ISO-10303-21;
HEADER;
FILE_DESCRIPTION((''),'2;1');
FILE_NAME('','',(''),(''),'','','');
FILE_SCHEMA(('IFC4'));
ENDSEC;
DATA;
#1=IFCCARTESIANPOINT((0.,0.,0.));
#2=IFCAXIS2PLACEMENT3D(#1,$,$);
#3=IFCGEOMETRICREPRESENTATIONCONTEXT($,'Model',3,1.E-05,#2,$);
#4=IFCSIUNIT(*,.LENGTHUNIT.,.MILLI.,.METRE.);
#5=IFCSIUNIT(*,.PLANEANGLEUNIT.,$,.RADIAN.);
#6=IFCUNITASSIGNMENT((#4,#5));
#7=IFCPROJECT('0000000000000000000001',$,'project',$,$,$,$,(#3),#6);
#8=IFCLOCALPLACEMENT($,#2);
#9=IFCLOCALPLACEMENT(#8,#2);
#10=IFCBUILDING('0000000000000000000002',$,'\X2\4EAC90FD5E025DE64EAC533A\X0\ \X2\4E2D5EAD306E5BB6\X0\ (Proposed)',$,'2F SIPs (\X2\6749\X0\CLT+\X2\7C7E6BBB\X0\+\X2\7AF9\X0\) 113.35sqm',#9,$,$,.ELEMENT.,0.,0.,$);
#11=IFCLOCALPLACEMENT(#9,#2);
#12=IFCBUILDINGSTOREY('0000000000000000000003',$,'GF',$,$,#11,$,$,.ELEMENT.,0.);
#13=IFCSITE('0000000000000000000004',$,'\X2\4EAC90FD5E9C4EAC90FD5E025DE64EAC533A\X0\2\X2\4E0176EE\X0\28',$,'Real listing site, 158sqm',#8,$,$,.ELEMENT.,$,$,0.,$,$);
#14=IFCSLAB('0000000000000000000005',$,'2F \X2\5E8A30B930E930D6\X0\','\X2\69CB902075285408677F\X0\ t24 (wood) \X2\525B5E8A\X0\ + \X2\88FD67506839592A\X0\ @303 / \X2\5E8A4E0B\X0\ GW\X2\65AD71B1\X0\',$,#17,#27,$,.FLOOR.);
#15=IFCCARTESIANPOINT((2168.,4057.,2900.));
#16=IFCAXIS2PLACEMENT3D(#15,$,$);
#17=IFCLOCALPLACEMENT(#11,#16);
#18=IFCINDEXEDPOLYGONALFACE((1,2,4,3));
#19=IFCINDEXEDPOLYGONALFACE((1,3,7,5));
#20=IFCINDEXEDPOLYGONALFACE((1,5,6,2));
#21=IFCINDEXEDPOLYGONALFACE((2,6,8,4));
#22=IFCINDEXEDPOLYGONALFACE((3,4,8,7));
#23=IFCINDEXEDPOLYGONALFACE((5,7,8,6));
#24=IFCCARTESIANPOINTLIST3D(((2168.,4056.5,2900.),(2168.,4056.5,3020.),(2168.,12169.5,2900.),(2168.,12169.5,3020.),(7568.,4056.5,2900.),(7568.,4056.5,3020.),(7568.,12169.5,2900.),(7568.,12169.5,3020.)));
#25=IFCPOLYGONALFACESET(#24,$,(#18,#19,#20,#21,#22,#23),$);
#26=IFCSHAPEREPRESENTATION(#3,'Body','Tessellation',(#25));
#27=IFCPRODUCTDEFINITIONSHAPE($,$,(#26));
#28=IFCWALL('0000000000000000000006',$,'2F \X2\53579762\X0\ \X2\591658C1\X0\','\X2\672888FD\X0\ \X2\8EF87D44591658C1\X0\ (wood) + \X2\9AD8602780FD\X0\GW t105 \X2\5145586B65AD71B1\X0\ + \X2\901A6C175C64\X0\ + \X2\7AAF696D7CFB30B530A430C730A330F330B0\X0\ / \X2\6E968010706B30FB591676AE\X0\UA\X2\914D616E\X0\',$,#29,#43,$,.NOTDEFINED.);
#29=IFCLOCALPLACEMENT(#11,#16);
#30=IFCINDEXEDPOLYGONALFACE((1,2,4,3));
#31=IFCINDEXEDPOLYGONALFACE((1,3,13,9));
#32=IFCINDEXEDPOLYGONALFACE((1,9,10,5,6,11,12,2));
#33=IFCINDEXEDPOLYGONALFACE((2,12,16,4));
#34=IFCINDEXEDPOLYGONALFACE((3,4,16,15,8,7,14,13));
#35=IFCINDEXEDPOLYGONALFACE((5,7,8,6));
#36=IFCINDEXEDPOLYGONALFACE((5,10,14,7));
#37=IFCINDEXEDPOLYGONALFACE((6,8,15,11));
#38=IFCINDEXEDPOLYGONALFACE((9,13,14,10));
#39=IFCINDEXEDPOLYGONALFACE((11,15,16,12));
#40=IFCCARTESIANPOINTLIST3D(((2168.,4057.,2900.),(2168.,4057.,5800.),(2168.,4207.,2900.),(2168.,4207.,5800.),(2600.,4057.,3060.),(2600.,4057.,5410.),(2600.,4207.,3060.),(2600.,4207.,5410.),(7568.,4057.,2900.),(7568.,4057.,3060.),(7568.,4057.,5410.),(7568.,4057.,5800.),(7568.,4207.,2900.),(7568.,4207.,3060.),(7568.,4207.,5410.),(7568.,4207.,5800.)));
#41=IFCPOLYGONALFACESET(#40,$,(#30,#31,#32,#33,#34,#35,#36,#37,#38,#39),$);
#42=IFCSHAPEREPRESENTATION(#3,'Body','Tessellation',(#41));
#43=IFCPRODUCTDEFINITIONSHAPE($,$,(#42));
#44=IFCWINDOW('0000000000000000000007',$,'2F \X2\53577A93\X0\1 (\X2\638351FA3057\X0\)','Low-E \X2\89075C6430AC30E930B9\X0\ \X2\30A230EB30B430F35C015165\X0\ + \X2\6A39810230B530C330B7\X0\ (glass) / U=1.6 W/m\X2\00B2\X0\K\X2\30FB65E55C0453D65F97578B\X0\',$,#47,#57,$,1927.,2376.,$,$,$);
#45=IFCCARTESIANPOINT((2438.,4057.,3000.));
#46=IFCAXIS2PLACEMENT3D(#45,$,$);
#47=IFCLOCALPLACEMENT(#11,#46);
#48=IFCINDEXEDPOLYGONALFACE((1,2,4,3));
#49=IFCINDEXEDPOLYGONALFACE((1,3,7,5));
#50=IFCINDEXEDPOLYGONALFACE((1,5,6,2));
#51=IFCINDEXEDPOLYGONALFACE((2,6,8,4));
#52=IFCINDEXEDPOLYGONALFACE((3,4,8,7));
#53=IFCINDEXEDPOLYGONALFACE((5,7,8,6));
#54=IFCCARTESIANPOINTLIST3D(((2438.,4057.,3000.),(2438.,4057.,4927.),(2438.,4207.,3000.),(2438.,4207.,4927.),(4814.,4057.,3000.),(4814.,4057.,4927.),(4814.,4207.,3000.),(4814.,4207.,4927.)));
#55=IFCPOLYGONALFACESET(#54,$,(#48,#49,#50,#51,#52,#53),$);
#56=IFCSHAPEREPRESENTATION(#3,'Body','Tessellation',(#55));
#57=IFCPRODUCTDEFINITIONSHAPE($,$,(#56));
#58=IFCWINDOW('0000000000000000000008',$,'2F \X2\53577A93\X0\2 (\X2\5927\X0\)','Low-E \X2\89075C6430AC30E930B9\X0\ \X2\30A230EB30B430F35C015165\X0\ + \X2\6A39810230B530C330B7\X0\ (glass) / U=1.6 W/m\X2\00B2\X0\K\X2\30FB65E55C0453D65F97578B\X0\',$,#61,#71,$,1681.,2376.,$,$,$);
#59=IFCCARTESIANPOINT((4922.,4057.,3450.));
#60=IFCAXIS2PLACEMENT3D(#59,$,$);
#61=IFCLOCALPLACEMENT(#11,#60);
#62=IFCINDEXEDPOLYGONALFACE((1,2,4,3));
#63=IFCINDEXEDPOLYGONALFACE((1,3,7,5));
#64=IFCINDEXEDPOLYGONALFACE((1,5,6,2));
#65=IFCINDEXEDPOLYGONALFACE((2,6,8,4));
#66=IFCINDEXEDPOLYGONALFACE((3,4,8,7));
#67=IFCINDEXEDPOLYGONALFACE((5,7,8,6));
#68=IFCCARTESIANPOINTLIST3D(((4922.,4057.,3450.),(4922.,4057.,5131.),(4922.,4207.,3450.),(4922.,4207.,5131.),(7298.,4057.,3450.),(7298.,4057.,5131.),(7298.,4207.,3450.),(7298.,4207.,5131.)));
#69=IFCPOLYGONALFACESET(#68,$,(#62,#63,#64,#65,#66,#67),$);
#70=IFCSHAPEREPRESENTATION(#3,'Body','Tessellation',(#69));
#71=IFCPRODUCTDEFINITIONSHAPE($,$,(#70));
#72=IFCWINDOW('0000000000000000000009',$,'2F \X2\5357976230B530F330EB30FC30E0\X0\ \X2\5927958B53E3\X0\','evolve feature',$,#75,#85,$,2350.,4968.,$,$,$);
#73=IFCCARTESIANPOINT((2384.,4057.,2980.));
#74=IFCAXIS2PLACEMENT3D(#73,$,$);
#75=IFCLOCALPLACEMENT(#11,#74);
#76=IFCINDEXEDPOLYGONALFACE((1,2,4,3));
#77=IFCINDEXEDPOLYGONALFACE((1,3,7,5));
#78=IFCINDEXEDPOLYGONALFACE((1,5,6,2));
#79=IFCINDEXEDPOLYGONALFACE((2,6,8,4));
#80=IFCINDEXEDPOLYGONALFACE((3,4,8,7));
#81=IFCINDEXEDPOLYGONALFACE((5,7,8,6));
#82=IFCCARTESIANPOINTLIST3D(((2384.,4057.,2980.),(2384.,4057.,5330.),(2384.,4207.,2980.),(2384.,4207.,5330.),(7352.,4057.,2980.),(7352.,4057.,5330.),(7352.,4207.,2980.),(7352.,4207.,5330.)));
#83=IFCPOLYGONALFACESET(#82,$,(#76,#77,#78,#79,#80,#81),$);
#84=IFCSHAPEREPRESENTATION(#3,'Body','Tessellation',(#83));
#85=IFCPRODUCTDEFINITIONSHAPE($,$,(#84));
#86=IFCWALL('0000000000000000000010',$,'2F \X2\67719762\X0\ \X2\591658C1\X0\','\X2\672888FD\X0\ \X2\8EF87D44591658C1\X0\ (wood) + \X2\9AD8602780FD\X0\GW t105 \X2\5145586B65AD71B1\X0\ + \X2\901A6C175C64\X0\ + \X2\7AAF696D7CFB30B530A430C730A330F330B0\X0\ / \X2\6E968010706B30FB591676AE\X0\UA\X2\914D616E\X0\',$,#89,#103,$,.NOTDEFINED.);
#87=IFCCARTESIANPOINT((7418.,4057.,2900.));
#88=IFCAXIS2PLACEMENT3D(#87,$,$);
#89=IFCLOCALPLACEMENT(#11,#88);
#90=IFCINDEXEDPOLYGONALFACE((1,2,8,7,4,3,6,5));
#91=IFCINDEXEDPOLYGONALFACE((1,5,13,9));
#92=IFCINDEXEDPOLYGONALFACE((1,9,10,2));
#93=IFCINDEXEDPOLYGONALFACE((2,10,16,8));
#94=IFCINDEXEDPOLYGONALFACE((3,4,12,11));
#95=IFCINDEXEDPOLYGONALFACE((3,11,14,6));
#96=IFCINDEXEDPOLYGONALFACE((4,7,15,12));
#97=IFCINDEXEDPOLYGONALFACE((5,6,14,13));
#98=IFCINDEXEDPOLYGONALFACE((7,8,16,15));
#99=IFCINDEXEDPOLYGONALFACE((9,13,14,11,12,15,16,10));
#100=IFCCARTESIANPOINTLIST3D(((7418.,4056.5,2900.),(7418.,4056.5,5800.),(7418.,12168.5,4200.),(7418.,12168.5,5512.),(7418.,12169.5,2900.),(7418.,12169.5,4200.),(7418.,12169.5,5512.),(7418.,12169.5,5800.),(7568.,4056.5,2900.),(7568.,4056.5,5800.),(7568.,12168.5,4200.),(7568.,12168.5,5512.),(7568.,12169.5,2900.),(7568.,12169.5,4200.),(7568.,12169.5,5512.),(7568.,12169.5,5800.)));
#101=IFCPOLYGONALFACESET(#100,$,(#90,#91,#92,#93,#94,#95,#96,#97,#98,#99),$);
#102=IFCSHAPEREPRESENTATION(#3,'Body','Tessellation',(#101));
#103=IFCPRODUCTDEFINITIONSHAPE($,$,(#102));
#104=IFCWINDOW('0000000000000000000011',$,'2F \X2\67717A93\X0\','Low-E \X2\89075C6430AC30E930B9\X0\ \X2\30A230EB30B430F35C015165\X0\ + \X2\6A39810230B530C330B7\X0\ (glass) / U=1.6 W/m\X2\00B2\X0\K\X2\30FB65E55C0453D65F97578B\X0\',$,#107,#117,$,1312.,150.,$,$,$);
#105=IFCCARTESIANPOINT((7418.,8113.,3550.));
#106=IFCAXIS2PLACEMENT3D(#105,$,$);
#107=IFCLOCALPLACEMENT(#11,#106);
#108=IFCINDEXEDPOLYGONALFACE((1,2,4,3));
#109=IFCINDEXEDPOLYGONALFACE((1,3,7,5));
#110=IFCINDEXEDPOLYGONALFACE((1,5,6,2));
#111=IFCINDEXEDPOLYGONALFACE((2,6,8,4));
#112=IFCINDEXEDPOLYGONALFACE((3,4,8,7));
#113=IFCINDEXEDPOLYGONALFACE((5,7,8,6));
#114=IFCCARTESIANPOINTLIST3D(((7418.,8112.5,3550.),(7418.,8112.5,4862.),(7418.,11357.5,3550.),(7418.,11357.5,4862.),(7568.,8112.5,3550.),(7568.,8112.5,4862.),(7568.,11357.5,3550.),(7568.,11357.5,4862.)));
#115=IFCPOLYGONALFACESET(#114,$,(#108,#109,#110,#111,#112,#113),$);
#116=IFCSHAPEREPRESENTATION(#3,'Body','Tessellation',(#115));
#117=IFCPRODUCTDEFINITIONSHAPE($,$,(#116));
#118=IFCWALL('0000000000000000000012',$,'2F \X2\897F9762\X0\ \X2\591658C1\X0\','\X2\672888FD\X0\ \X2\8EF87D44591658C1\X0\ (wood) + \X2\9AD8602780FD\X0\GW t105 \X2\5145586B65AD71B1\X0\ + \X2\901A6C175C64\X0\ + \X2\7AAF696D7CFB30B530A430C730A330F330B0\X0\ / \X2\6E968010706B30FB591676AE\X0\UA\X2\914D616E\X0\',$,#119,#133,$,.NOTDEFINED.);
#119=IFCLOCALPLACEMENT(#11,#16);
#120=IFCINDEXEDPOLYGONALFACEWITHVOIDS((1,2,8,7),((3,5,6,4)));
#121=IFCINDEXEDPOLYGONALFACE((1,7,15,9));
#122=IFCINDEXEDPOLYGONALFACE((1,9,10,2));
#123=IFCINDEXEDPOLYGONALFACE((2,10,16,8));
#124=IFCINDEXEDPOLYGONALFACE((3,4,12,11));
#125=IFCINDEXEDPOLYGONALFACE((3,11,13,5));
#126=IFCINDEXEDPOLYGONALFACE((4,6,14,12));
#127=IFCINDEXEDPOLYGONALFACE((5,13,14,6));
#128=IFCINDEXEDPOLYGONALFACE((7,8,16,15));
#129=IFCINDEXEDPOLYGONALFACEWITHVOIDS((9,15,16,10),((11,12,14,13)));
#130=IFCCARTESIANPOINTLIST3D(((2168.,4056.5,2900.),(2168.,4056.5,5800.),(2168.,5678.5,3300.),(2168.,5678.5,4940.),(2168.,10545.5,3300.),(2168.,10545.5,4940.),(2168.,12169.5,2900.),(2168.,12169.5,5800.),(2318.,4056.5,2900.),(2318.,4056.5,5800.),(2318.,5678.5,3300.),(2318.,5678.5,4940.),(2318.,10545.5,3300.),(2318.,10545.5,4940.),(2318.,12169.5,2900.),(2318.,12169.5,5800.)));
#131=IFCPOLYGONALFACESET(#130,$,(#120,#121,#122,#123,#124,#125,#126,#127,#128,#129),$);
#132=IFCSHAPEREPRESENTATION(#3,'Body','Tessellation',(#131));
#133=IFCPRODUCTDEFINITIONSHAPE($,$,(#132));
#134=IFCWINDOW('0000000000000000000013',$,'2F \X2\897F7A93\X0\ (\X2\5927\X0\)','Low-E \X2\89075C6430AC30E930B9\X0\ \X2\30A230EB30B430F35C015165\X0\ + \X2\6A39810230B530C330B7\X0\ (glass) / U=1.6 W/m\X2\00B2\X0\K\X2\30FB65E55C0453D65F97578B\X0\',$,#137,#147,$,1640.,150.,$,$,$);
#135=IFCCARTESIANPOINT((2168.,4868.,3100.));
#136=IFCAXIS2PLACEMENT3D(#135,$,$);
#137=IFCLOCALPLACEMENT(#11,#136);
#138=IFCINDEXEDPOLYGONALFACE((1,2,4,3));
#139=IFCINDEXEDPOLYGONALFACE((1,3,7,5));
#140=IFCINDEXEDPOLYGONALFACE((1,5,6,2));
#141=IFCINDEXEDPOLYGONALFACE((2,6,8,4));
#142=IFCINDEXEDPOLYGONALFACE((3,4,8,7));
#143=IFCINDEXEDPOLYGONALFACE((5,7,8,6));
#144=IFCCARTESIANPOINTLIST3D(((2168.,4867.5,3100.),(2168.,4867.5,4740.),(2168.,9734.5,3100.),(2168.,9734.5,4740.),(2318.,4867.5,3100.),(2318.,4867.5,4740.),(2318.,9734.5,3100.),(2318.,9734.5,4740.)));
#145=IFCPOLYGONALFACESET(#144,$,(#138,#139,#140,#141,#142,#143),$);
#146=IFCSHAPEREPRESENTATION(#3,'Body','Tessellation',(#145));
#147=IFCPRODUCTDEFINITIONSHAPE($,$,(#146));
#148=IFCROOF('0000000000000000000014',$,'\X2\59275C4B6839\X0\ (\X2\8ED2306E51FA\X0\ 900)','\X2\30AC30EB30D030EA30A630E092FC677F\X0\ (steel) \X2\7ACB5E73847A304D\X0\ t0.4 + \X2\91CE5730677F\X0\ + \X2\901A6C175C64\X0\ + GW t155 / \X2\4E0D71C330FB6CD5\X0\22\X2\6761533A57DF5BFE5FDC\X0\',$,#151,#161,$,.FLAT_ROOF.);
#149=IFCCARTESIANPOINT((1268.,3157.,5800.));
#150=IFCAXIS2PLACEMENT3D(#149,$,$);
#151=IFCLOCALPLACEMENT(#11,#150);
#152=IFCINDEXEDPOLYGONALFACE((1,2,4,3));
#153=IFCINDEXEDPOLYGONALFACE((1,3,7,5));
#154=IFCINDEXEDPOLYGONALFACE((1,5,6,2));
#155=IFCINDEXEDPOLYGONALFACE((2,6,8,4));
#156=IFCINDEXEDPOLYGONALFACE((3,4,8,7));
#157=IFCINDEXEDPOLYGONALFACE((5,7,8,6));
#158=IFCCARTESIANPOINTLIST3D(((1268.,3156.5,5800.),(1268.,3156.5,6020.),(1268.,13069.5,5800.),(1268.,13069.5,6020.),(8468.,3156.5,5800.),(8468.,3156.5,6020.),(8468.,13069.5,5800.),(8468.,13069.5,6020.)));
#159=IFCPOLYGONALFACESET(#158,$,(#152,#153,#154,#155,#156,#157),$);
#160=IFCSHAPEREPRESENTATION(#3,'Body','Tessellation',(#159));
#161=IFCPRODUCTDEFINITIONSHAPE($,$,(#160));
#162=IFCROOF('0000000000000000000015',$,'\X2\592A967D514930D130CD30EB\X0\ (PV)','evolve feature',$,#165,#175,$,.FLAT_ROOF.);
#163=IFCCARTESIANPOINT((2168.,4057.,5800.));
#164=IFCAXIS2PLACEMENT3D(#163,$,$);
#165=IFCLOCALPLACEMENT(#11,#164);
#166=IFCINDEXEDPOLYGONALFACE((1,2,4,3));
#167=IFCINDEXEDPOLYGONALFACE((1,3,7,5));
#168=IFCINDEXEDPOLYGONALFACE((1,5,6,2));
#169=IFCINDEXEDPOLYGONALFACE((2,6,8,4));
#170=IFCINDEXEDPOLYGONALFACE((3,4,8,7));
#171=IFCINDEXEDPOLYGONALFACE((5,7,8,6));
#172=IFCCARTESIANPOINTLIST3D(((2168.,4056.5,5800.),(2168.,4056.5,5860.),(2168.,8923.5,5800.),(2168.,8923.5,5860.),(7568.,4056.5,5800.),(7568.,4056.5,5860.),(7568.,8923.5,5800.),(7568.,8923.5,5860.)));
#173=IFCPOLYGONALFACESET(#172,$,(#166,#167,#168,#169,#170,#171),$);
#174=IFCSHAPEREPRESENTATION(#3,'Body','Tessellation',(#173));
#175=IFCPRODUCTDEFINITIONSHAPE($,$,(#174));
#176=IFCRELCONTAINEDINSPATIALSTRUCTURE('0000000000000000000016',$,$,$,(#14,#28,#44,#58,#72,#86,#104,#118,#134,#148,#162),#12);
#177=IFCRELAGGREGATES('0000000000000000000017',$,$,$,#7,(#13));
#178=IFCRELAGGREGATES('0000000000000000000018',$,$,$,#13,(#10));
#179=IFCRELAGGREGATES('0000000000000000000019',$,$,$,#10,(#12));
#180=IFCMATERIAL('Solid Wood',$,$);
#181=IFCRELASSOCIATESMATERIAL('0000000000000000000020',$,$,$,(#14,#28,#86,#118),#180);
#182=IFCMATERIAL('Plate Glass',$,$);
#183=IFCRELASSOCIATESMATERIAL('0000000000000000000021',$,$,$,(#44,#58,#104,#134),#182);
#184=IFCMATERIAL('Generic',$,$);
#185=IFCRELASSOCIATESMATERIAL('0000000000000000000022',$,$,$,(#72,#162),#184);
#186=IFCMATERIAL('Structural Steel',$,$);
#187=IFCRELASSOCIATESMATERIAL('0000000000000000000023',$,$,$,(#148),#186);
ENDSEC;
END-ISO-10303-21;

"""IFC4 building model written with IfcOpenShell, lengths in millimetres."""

from ifc_helpers import new_model, si_unit, frame, frame_2d, origin, place, context, project, spatial, rectangle, extrude, material, element, fill, save


model = new_model("IFC4")

# Units and contexts
model_context = context("Model", 3, precision=1e-05, world=origin())
ifc_project = project(units=[si_unit("LENGTHUNIT", "METRE", prefix="MILLI"), si_unit("PLANEANGLEUNIT", "RADIAN")], contexts=[model_context])

# Site, building, storey
site_placement = place(None, origin())
site = spatial("IfcSite", under=ifc_project, at=site_placement, Name="京都府京都市左京区2丁目28", ObjectType="Real listing site, 158sqm", CompositionType="ELEMENT", RefElevation=0.0)
building_placement = place(site_placement, origin())
building = spatial("IfcBuilding", under=site, at=building_placement, Name="京都市左京区 中庭の家 (Proposed)", ObjectType="2F SIPs (杉CLT+籾殻+竹) 113.35sqm", CompositionType="ELEMENT", ElevationOfRefHeight=0.0, ElevationOfTerrain=0.0)
storey_placement = place(building_placement, origin())
storey = spatial("IfcBuildingStorey", under=building, at=storey_placement, Name="GF", CompositionType="ELEMENT", Elevation=0.0)

# Slab
ifc_material_1 = material(Name="Solid Wood")
slab_placement = place(storey_placement, frame((2168.0, 4057.0, 2900.0)))
element("IfcSlab", 1, at=slab_placement, inside=storey, material=ifc_material_1, Name="2F 床スラブ", Description="構造用合板 t24 (wood) 剛床 + 製材根太 @303 / 床下 GW断熱", PredefinedType="FLOOR", context=model_context, shape_type="SweptSolid", body=[
    extrude(rectangle(XDim=5400.0, YDim=8113.0, at=frame_2d((2700.0, 4056.0))), frame((2168.0, 4057.0, 2900.0)), (0.0, 0.0, 1.0), 120.0),
])

# Wall, openings, windows
wall_1_placement = place(storey_placement, frame((2168.0, 4057.0, 2900.0)))
wall_1 = element("IfcWall", 2, at=wall_1_placement, inside=storey, material=ifc_material_1, Name="2F 南面 外壁", Description="木製 軸組外壁 (wood) + 高性能GW t105 充填断熱 + 通気層 + 窯業系サイディング / 準耐火・外皮UA配慮", PredefinedType="NOTDEFINED", context=model_context, shape_type="SweptSolid", body=[
    extrude(rectangle(XDim=5400.0, YDim=150.0, at=frame_2d((2700.0, 75.0))), frame((2168.0, 4057.0, 2900.0)), (0.0, 0.0, 1.0), 2900.0),
])
opening_1_placement = place(storey_placement, frame((2438.0, 4057.0, 3000.0)))
opening_1 = element("IfcOpeningElement", 3, at=opening_1_placement, cuts=wall_1, PredefinedType="NOTDEFINED", context=model_context, shape_type="SweptSolid", body=[
    extrude(rectangle(XDim=2376.0, YDim=150.0, at=frame_2d((1188.0, 75.0))), frame((2438.0, 4057.0, 3000.0)), (0.0, 0.0, 1.0), 1927.0),
])
opening_2_placement = place(storey_placement, frame((4922.0, 4057.0, 3450.0)))
opening_2 = element("IfcOpeningElement", 4, at=opening_2_placement, cuts=wall_1, PredefinedType="NOTDEFINED", context=model_context, shape_type="SweptSolid", body=[
    extrude(rectangle(XDim=2376.0, YDim=150.0, at=frame_2d((1188.0, 75.0))), frame((4922.0, 4057.0, 3450.0)), (0.0, 0.0, 1.0), 1681.0),
])
opening_3_placement = place(storey_placement, frame((2384.0, 4057.0, 2980.0)))
opening_3 = element("IfcOpeningElement", 5, at=opening_3_placement, cuts=wall_1, PredefinedType="NOTDEFINED", context=model_context, shape_type="SweptSolid", body=[
    extrude(rectangle(XDim=4968.0, YDim=150.0, at=frame_2d((2484.0, 75.0))), frame((2384.0, 4057.0, 2980.0)), (0.0, 0.0, 1.0), 2350.0),
])
ifc_material_2 = material(Name="Plate Glass")
window_1_placement = place(storey_placement, frame((2438.0, 4057.0, 3000.0)))
window_1 = element("IfcWindow", 6, at=window_1_placement, inside=storey, material=ifc_material_2, Name="2F 南窓1 (掃出し)", Description="Low-E 複層ガラス アルゴン封入 + 樹脂サッシ (glass) / U=1.6 W/m²K・日射取得型", OverallHeight=1927.0, OverallWidth=2376.0, context=model_context, shape_type="SweptSolid", body=[
    extrude(rectangle(XDim=2376.0, YDim=150.0, at=frame_2d((1188.0, 75.0))), frame((2438.0, 4057.0, 3000.0)), (0.0, 0.0, 1.0), 1927.0),
])
fill(opening_1, window_1)
window_2_placement = place(storey_placement, frame((4922.0, 4057.0, 3450.0)))
window_2 = element("IfcWindow", 7, at=window_2_placement, inside=storey, material=ifc_material_2, Name="2F 南窓2 (大)", Description="Low-E 複層ガラス アルゴン封入 + 樹脂サッシ (glass) / U=1.6 W/m²K・日射取得型", OverallHeight=1681.0, OverallWidth=2376.0, context=model_context, shape_type="SweptSolid", body=[
    extrude(rectangle(XDim=2376.0, YDim=150.0, at=frame_2d((1188.0, 75.0))), frame((4922.0, 4057.0, 3450.0)), (0.0, 0.0, 1.0), 1681.0),
])
fill(opening_2, window_2)
ifc_material_3 = material(Name="Generic")
window_3_placement = place(storey_placement, frame((2384.0, 4057.0, 2980.0)))
window_3 = element("IfcWindow", 8, at=window_3_placement, inside=storey, material=ifc_material_3, Name="2F 南面サンルーム 大開口", Description="evolve feature", OverallHeight=2350.0, OverallWidth=4968.0, context=model_context, shape_type="SweptSolid", body=[
    extrude(rectangle(XDim=4968.0, YDim=150.0, at=frame_2d((2484.0, 75.0))), frame((2384.0, 4057.0, 2980.0)), (0.0, 0.0, 1.0), 2350.0),
])
fill(opening_3, window_3)

# Walls, openings, windows
wall_2_placement = place(storey_placement, frame((7418.0, 4057.0, 2900.0)))
wall_2 = element("IfcWall", 9, at=wall_2_placement, inside=storey, material=ifc_material_1, Name="2F 東面 外壁", Description="木製 軸組外壁 (wood) + 高性能GW t105 充填断熱 + 通気層 + 窯業系サイディング / 準耐火・外皮UA配慮", PredefinedType="NOTDEFINED", context=model_context, shape_type="SweptSolid", body=[
    extrude(rectangle(XDim=150.0, YDim=8113.0, at=frame_2d((75.0, 4056.0))), frame((7418.0, 4057.0, 2900.0)), (0.0, 0.0, 1.0), 2900.0),
])
opening_4_placement = place(storey_placement, frame((7418.0, 8113.0, 3550.0)))
opening_4 = element("IfcOpeningElement", 10, at=opening_4_placement, cuts=wall_2, PredefinedType="NOTDEFINED", context=model_context, shape_type="SweptSolid", body=[
    extrude(rectangle(XDim=150.0, YDim=3245.0, at=frame_2d((75.0, 1622.0))), frame((7418.0, 8113.0, 3550.0)), (0.0, 0.0, 1.0), 1312.0),
])
window_4_placement = place(storey_placement, frame((7418.0, 8113.0, 3550.0)))
window_4 = element("IfcWindow", 11, at=window_4_placement, inside=storey, material=ifc_material_2, Name="2F 東窓", Description="Low-E 複層ガラス アルゴン封入 + 樹脂サッシ (glass) / U=1.6 W/m²K・日射取得型", OverallHeight=1312.0, OverallWidth=150.0, context=model_context, shape_type="SweptSolid", body=[
    extrude(rectangle(XDim=150.0, YDim=3245.0, at=frame_2d((75.0, 1622.0))), frame((7418.0, 8113.0, 3550.0)), (0.0, 0.0, 1.0), 1312.0),
])
fill(opening_4, window_4)
wall_3_placement = place(storey_placement, frame((2168.0, 4057.0, 2900.0)))
wall_3 = element("IfcWall", 12, at=wall_3_placement, inside=storey, material=ifc_material_1, Name="2F 西面 外壁", Description="木製 軸組外壁 (wood) + 高性能GW t105 充填断熱 + 通気層 + 窯業系サイディング / 準耐火・外皮UA配慮", PredefinedType="NOTDEFINED", context=model_context, shape_type="SweptSolid", body=[
    extrude(rectangle(XDim=150.0, YDim=8113.0, at=frame_2d((75.0, 4056.0))), frame((2168.0, 4057.0, 2900.0)), (0.0, 0.0, 1.0), 2900.0),
])
opening_5_placement = place(storey_placement, frame((2168.0, 4868.0, 3100.0)))
opening_5 = element("IfcOpeningElement", 13, at=opening_5_placement, cuts=wall_3, PredefinedType="NOTDEFINED", context=model_context, shape_type="SweptSolid", body=[
    extrude(rectangle(XDim=150.0, YDim=4867.0, at=frame_2d((75.0, 2433.0))), frame((2168.0, 4868.0, 3100.0)), (0.0, 0.0, 1.0), 1640.0),
])
window_5_placement = place(storey_placement, frame((2168.0, 4868.0, 3100.0)))
window_5 = element("IfcWindow", 14, at=window_5_placement, inside=storey, material=ifc_material_2, Name="2F 西窓 (大)", Description="Low-E 複層ガラス アルゴン封入 + 樹脂サッシ (glass) / U=1.6 W/m²K・日射取得型", OverallHeight=1640.0, OverallWidth=150.0, context=model_context, shape_type="SweptSolid", body=[
    extrude(rectangle(XDim=150.0, YDim=4867.0, at=frame_2d((75.0, 2433.0))), frame((2168.0, 4868.0, 3100.0)), (0.0, 0.0, 1.0), 1640.0),
])
fill(opening_5, window_5)

# Roofs
ifc_material_4 = material(Name="Structural Steel")
roof_1_placement = place(storey_placement, frame((1268.0, 3157.0, 5800.0)))
element("IfcRoof", 15, at=roof_1_placement, inside=storey, material=ifc_material_4, Name="大屋根 (軒の出 900)", Description="ガルバリウム鋼板 (steel) 立平葺き t0.4 + 野地板 + 通気層 + GW t155 / 不燃・法22条区域対応", PredefinedType="FLAT_ROOF", context=model_context, shape_type="SweptSolid", body=[
    extrude(rectangle(XDim=7200.0, YDim=9913.0, at=frame_2d((3600.0, 4956.0))), frame((1268.0, 3157.0, 5800.0)), (0.0, 0.0, 1.0), 220.0),
])
roof_2_placement = place(storey_placement, frame((2168.0, 4057.0, 5800.0)))
element("IfcRoof", 16, at=roof_2_placement, inside=storey, material=ifc_material_3, Name="太陽光パネル (PV)", Description="evolve feature", PredefinedType="FLAT_ROOF", context=model_context, shape_type="SweptSolid", body=[
    extrude(rectangle(XDim=5400.0, YDim=4867.0, at=frame_2d((2700.0, 2433.0))), frame((2168.0, 4057.0, 5800.0)), (0.0, 0.0, 1.0), 60.0),
])

save(model, "model.ifc")
